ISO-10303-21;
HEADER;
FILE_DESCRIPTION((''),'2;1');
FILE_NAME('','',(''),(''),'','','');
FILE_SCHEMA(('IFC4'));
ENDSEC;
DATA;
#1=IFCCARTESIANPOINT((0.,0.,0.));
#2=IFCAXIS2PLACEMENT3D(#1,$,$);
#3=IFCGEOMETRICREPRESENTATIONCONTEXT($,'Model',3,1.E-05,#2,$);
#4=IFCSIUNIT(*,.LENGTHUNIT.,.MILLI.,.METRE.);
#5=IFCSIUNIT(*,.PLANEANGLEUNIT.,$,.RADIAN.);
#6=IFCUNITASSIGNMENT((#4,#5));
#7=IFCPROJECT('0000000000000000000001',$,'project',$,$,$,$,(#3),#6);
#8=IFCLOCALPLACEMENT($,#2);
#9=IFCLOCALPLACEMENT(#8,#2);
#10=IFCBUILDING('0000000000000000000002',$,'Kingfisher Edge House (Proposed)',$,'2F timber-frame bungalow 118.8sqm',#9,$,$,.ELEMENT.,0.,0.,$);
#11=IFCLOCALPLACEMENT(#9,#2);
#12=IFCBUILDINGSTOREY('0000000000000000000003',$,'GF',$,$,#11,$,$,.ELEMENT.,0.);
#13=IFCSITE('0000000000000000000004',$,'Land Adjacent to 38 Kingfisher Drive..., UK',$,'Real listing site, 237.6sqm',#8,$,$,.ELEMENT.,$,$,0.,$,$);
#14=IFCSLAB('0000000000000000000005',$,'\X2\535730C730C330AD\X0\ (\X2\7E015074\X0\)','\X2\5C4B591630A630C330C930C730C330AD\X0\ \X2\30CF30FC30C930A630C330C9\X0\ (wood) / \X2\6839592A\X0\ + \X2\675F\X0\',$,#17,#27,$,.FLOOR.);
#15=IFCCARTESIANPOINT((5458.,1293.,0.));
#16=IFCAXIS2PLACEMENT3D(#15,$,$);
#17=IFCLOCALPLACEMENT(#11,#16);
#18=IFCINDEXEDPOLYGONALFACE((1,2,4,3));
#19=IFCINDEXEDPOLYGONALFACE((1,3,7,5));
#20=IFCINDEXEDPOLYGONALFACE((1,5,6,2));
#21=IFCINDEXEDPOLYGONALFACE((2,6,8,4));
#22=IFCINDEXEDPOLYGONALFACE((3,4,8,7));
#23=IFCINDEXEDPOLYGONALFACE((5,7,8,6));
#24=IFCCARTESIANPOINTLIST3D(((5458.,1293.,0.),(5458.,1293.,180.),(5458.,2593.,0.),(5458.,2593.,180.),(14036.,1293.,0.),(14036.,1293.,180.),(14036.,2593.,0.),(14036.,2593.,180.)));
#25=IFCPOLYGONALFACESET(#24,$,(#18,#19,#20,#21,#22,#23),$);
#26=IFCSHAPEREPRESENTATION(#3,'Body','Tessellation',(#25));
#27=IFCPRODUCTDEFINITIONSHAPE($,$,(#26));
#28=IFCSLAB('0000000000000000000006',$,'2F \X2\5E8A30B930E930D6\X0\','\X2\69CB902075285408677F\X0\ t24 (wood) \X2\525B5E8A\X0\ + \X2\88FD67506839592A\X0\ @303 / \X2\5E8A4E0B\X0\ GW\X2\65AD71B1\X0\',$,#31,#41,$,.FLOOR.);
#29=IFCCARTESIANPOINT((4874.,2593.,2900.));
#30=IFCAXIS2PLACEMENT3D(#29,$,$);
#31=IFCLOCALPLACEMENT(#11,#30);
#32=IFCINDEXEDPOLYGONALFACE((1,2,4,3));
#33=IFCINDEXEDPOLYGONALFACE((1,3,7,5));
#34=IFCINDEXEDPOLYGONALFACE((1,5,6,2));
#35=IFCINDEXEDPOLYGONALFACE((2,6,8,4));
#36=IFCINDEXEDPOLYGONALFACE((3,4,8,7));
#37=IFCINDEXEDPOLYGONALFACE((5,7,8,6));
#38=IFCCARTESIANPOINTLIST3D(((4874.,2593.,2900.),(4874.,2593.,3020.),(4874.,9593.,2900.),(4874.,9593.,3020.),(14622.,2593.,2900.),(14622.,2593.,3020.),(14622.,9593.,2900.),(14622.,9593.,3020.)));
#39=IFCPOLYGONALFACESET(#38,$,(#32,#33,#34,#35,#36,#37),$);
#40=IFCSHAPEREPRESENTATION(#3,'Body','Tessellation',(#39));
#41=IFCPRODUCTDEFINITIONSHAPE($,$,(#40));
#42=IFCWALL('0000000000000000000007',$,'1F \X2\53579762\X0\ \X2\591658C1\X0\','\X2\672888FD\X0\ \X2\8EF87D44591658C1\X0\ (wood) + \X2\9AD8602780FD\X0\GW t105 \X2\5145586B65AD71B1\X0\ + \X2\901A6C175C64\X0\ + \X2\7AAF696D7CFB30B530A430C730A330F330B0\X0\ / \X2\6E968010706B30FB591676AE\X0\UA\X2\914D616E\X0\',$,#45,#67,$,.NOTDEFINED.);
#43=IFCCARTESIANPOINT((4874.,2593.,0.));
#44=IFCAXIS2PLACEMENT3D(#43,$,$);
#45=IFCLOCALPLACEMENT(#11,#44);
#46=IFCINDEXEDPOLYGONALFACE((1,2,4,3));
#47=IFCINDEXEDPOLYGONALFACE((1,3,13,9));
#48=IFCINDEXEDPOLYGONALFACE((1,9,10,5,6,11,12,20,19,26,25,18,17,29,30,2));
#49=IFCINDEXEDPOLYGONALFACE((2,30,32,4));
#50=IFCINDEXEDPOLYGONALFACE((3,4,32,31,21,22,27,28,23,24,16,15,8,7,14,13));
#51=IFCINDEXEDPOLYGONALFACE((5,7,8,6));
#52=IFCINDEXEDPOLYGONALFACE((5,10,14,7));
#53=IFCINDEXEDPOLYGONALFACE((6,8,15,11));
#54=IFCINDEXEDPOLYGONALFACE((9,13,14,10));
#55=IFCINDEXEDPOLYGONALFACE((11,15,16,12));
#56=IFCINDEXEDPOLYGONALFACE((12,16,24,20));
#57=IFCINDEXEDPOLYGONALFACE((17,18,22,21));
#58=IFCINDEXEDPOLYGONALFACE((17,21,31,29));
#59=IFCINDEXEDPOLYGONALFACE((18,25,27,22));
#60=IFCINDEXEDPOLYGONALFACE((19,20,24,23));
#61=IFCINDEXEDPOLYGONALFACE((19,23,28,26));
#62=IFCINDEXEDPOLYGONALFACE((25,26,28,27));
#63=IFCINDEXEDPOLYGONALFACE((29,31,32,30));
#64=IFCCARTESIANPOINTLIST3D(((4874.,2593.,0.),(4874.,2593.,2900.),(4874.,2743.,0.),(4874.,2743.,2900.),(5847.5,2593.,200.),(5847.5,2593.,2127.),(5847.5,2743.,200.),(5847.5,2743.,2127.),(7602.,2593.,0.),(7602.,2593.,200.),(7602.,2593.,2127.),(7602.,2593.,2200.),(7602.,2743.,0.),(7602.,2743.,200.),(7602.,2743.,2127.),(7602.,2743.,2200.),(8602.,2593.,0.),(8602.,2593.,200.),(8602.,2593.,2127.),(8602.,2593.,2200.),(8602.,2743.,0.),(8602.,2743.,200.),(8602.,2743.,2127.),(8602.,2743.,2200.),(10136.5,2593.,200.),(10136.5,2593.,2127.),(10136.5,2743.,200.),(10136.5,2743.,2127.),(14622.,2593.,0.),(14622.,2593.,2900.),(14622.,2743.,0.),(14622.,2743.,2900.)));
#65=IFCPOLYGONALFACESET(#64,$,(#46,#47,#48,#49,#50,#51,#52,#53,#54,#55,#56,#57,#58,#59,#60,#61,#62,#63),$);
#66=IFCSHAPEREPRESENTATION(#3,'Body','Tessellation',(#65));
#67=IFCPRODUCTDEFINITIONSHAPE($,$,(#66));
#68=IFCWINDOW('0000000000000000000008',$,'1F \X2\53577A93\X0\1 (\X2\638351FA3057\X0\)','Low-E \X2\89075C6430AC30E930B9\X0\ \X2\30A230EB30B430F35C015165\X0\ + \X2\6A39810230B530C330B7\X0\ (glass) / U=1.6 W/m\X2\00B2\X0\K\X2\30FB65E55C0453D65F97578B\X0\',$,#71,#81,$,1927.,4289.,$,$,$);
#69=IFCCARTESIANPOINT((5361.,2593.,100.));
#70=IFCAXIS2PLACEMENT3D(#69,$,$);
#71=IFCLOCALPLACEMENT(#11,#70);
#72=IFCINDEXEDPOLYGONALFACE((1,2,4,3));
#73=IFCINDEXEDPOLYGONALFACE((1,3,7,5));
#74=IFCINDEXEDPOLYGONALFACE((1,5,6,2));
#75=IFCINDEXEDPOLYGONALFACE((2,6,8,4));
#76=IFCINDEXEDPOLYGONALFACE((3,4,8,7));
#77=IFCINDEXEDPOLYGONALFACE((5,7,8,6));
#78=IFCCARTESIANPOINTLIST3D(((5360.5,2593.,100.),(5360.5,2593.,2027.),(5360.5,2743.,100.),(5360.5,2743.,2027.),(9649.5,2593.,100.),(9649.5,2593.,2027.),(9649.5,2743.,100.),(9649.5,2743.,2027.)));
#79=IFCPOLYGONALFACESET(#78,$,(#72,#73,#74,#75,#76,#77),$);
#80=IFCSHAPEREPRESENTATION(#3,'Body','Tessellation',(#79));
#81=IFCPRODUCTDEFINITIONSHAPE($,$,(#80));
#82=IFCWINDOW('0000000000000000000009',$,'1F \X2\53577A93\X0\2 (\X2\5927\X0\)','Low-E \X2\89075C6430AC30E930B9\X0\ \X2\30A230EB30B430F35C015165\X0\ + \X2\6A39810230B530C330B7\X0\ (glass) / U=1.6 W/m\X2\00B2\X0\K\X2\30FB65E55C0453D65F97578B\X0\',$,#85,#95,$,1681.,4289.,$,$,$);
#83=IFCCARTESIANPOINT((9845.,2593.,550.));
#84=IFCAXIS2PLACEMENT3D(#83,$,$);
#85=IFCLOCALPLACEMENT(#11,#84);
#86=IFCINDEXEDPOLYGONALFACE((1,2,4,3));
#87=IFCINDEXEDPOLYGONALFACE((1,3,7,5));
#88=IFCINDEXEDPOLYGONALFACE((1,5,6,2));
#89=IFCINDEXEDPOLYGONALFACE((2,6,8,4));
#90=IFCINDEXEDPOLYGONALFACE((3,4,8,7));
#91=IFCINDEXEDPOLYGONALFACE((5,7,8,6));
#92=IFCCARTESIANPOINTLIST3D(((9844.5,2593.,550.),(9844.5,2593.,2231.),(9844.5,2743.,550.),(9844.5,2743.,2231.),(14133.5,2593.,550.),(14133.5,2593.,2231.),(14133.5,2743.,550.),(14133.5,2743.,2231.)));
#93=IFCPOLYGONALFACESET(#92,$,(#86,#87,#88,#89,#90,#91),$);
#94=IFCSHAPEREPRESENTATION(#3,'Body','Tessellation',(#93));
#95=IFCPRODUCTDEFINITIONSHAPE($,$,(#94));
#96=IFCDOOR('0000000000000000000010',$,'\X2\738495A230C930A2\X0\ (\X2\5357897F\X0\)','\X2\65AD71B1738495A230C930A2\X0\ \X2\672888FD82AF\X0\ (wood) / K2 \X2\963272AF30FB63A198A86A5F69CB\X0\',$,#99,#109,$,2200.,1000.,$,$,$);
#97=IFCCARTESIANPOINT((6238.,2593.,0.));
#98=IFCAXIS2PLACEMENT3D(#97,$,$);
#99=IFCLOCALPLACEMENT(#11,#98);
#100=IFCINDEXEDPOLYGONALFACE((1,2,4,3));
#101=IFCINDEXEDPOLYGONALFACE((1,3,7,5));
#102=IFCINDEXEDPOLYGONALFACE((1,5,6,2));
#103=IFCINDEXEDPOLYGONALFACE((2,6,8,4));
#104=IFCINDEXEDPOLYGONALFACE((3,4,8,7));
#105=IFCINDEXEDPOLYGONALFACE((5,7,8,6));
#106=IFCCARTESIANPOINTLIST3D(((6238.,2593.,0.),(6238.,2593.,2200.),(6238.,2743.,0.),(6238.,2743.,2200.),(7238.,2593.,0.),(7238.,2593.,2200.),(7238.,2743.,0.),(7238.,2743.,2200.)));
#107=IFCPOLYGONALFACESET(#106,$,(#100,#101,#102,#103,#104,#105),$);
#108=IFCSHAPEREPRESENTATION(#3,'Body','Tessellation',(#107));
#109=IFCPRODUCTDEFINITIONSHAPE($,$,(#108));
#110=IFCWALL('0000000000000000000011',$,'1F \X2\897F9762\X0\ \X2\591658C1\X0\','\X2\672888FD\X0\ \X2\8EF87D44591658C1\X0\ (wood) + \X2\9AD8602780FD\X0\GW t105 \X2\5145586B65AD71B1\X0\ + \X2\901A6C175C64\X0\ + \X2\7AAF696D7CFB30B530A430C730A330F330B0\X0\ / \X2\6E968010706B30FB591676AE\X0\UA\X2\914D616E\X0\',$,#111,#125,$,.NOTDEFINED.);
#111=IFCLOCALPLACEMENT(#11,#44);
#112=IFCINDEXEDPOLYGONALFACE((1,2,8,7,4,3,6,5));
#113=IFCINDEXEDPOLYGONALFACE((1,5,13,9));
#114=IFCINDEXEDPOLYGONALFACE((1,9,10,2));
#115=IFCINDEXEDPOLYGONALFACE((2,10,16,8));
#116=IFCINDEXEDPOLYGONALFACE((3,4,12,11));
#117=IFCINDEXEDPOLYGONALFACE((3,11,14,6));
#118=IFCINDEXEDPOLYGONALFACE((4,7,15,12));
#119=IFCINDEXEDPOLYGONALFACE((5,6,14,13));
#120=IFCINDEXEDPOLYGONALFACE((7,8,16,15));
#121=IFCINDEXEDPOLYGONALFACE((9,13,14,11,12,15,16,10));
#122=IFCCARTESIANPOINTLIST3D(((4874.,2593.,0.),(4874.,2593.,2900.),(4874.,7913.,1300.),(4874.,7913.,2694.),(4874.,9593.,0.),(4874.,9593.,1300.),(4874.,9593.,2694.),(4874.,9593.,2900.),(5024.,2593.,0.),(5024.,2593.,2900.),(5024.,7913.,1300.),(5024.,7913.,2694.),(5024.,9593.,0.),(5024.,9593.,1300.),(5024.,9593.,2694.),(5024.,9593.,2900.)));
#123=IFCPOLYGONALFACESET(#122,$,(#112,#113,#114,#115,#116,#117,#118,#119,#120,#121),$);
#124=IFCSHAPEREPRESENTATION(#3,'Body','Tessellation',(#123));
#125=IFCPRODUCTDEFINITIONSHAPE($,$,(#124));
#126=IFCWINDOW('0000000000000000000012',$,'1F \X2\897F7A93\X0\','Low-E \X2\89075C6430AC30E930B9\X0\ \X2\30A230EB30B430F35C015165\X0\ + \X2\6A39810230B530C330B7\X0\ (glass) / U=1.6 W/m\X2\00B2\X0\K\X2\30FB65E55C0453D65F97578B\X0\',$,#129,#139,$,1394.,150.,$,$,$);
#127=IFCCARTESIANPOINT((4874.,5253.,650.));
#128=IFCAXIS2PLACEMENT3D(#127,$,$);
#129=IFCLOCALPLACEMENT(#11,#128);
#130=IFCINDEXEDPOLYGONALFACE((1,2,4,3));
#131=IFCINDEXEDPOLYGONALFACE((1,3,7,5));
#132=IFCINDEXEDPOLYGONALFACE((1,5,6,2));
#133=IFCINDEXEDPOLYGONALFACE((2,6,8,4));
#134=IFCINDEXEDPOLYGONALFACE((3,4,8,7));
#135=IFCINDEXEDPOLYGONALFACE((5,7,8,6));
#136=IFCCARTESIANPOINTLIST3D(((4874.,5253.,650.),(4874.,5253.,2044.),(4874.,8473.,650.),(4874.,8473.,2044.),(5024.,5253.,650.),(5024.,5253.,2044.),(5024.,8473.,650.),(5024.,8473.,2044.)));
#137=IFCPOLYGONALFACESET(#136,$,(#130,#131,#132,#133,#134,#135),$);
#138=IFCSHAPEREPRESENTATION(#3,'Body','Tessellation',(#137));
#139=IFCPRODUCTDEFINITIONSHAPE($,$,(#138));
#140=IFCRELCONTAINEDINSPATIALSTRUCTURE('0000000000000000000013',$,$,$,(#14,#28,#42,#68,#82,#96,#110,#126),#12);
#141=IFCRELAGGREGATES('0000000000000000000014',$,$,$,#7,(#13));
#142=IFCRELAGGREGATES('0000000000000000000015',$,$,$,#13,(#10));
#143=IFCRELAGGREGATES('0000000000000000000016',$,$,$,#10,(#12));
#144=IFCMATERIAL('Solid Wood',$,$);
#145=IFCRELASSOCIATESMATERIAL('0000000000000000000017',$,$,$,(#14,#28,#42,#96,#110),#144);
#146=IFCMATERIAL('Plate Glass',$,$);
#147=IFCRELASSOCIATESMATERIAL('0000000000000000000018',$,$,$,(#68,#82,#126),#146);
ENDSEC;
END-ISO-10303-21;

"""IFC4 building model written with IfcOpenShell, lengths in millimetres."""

from ifc_helpers import new_model, si_unit, frame, frame_2d, origin, place, context, project, spatial, rectangle, extrude, material, element, fill, save


model = new_model("IFC4")

# Units and contexts
model_context = context("Model", 3, precision=1e-05, world=origin())
ifc_project = project(units=[si_unit("LENGTHUNIT", "METRE", prefix="MILLI"), si_unit("PLANEANGLEUNIT", "RADIAN")], contexts=[model_context])

# Site, building, storey
site_placement = place(None, origin())
site = spatial("IfcSite", under=ifc_project, at=site_placement, Name="Land Adjacent to 38 Kingfisher Drive..., UK", ObjectType="Real listing site, 237.6sqm", CompositionType="ELEMENT", RefElevation=0.0)
building_placement = place(site_placement, origin())
building = spatial("IfcBuilding", under=site, at=building_placement, Name="Kingfisher Edge House (Proposed)", ObjectType="2F timber-frame bungalow 118.8sqm", CompositionType="ELEMENT", ElevationOfRefHeight=0.0, ElevationOfTerrain=0.0)
storey_placement = place(building_placement, origin())
storey = spatial("IfcBuildingStorey", under=building, at=storey_placement, Name="GF", CompositionType="ELEMENT", Elevation=0.0)

# Slabs
ifc_material_1 = material(Name="Solid Wood")
slab_1_placement = place(storey_placement, frame((5458.0, 1293.0, 0.0)))
element("IfcSlab", 1, at=slab_1_placement, inside=storey, material=ifc_material_1, Name="南デッキ (縁側)", Description="屋外ウッドデッキ ハードウッド (wood) / 根太 + 束", PredefinedType="FLOOR", context=model_context, shape_type="SweptSolid", body=[
    extrude(rectangle(XDim=8578.0, YDim=1300.0, at=frame_2d((4289.0, 650.0))), frame((5458.0, 1293.0, 0.0)), (0.0, 0.0, 1.0), 180.0),
])
slab_2_placement = place(storey_placement, frame((4874.0, 2593.0, 2900.0)))
element("IfcSlab", 2, at=slab_2_placement, inside=storey, material=ifc_material_1, Name="2F 床スラブ", Description="構造用合板 t24 (wood) 剛床 + 製材根太 @303 / 床下 GW断熱", PredefinedType="FLOOR", context=model_context, shape_type="SweptSolid", body=[
    extrude(rectangle(XDim=9748.0, YDim=7000.0, at=frame_2d((4874.0, 3500.0))), frame((4874.0, 2593.0, 2900.0)), (0.0, 0.0, 1.0), 120.0),
])

# Wall, openings, windows, door
wall_1_placement = place(storey_placement, frame((4874.0, 2593.0, 0.0)))
wall_1 = element("IfcWall", 3, at=wall_1_placement, inside=storey, material=ifc_material_1, Name="1F 南面 外壁", Description="木製 軸組外壁 (wood) + 高性能GW t105 充填断熱 + 通気層 + 窯業系サイディング / 準耐火・外皮UA配慮", PredefinedType="NOTDEFINED", context=model_context, shape_type="SweptSolid", body=[
    extrude(rectangle(XDim=9748.0, YDim=150.0, at=frame_2d((4874.0, 75.0))), frame((4874.0, 2593.0, 0.0)), (0.0, 0.0, 1.0), 2900.0),
])
opening_1_placement = place(storey_placement, frame((5361.0, 2593.0, 100.0)))
opening_1 = element("IfcOpeningElement", 4, at=opening_1_placement, cuts=wall_1, PredefinedType="NOTDEFINED", context=model_context, shape_type="SweptSolid", body=[
    extrude(rectangle(XDim=4289.0, YDim=150.0, at=frame_2d((2144.0, 75.0))), frame((5361.0, 2593.0, 100.0)), (0.0, 0.0, 1.0), 1927.0),
])
opening_2_placement = place(storey_placement, frame((9845.0, 2593.0, 550.0)))
opening_2 = element("IfcOpeningElement", 5, at=opening_2_placement, cuts=wall_1, PredefinedType="NOTDEFINED", context=model_context, shape_type="SweptSolid", body=[
    extrude(rectangle(XDim=4289.0, YDim=150.0, at=frame_2d((2144.0, 75.0))), frame((9845.0, 2593.0, 550.0)), (0.0, 0.0, 1.0), 1681.0),
])
opening_3_placement = place(storey_placement, frame((6238.0, 2593.0, 0.0)))
opening_3 = element("IfcOpeningElement", 6, at=opening_3_placement, cuts=wall_1, PredefinedType="NOTDEFINED", context=model_context, shape_type="SweptSolid", body=[
    extrude(rectangle(XDim=1000.0, YDim=150.0, at=frame_2d((500.0, 75.0))), frame((6238.0, 2593.0, 0.0)), (0.0, 0.0, 1.0), 2200.0),
])
ifc_material_2 = material(Name="Plate Glass")
window_1_placement = place(storey_placement, frame((5361.0, 2593.0, 100.0)))
window_1 = element("IfcWindow", 7, at=window_1_placement, inside=storey, material=ifc_material_2, Name="1F 南窓1 (掃出し)", Description="Low-E 複層ガラス アルゴン封入 + 樹脂サッシ (glass) / U=1.6 W/m²K・日射取得型", OverallHeight=1927.0, OverallWidth=4289.0, context=model_context, shape_type="SweptSolid", body=[
    extrude(rectangle(XDim=4289.0, YDim=150.0, at=frame_2d((2144.0, 75.0))), frame((5361.0, 2593.0, 100.0)), (0.0, 0.0, 1.0), 1927.0),
])
fill(opening_1, window_1)
window_2_placement = place(storey_placement, frame((9845.0, 2593.0, 550.0)))
window_2 = element("IfcWindow", 8, at=window_2_placement, inside=storey, material=ifc_material_2, Name="1F 南窓2 (大)", Description="Low-E 複層ガラス アルゴン封入 + 樹脂サッシ (glass) / U=1.6 W/m²K・日射取得型", OverallHeight=1681.0, OverallWidth=4289.0, context=model_context, shape_type="SweptSolid", body=[
    extrude(rectangle(XDim=4289.0, YDim=150.0, at=frame_2d((2144.0, 75.0))), frame((9845.0, 2593.0, 550.0)), (0.0, 0.0, 1.0), 1681.0),
])
fill(opening_2, window_2)
door_placement = place(storey_placement, frame((6238.0, 2593.0, 0.0)))
door = element("IfcDoor", 9, at=door_placement, inside=storey, material=ifc_material_1, Name="玄関ドア (南西)", Description="断熱玄関ドア 木製芯 (wood) / K2 防犯・採風機構", OverallHeight=2200.0, OverallWidth=1000.0, context=model_context, shape_type="SweptSolid", body=[
    extrude(rectangle(XDim=1000.0, YDim=150.0, at=frame_2d((500.0, 75.0))), frame((6238.0, 2593.0, 0.0)), (0.0, 0.0, 1.0), 2200.0),
])
fill(opening_3, door)

# Wall, opening, window
wall_2_placement = place(storey_placement, frame((4874.0, 2593.0, 0.0)))
wall_2 = element("IfcWall", 10, at=wall_2_placement, inside=storey, material=ifc_material_1, Name="1F 西面 外壁", Description="木製 軸組外壁 (wood) + 高性能GW t105 充填断熱 + 通気層 + 窯業系サイディング / 準耐火・外皮UA配慮", PredefinedType="NOTDEFINED", context=model_context, shape_type="SweptSolid", body=[
    extrude(rectangle(XDim=150.0, YDim=7000.0, at=frame_2d((75.0, 3500.0))), frame((4874.0, 2593.0, 0.0)), (0.0, 0.0, 1.0), 2900.0),
])
opening_4_placement = place(storey_placement, frame((4874.0, 5253.0, 650.0)))
opening_4 = element("IfcOpeningElement", 11, at=opening_4_placement, cuts=wall_2, PredefinedType="NOTDEFINED", context=model_context, shape_type="SweptSolid", body=[
    extrude(rectangle(XDim=150.0, YDim=3220.0, at=frame_2d((75.0, 1610.0))), frame((4874.0, 5253.0, 650.0)), (0.0, 0.0, 1.0), 1394.0),
])
window_3_placement = place(storey_placement, frame((4874.0, 5253.0, 650.0)))
window_3 = element("IfcWindow", 12, at=window_3_placement, inside=storey, material=ifc_material_2, Name="1F 西窓", Description="Low-E 複層ガラス アルゴン封入 + 樹脂サッシ (glass) / U=1.6 W/m²K・日射取得型", OverallHeight=1394.0, OverallWidth=150.0, context=model_context, shape_type="SweptSolid", body=[
    extrude(rectangle(XDim=150.0, YDim=3220.0, at=frame_2d((75.0, 1610.0))), frame((4874.0, 5253.0, 650.0)), (0.0, 0.0, 1.0), 1394.0),
])
fill(opening_4, window_3)

save(model, "model.ifc")
